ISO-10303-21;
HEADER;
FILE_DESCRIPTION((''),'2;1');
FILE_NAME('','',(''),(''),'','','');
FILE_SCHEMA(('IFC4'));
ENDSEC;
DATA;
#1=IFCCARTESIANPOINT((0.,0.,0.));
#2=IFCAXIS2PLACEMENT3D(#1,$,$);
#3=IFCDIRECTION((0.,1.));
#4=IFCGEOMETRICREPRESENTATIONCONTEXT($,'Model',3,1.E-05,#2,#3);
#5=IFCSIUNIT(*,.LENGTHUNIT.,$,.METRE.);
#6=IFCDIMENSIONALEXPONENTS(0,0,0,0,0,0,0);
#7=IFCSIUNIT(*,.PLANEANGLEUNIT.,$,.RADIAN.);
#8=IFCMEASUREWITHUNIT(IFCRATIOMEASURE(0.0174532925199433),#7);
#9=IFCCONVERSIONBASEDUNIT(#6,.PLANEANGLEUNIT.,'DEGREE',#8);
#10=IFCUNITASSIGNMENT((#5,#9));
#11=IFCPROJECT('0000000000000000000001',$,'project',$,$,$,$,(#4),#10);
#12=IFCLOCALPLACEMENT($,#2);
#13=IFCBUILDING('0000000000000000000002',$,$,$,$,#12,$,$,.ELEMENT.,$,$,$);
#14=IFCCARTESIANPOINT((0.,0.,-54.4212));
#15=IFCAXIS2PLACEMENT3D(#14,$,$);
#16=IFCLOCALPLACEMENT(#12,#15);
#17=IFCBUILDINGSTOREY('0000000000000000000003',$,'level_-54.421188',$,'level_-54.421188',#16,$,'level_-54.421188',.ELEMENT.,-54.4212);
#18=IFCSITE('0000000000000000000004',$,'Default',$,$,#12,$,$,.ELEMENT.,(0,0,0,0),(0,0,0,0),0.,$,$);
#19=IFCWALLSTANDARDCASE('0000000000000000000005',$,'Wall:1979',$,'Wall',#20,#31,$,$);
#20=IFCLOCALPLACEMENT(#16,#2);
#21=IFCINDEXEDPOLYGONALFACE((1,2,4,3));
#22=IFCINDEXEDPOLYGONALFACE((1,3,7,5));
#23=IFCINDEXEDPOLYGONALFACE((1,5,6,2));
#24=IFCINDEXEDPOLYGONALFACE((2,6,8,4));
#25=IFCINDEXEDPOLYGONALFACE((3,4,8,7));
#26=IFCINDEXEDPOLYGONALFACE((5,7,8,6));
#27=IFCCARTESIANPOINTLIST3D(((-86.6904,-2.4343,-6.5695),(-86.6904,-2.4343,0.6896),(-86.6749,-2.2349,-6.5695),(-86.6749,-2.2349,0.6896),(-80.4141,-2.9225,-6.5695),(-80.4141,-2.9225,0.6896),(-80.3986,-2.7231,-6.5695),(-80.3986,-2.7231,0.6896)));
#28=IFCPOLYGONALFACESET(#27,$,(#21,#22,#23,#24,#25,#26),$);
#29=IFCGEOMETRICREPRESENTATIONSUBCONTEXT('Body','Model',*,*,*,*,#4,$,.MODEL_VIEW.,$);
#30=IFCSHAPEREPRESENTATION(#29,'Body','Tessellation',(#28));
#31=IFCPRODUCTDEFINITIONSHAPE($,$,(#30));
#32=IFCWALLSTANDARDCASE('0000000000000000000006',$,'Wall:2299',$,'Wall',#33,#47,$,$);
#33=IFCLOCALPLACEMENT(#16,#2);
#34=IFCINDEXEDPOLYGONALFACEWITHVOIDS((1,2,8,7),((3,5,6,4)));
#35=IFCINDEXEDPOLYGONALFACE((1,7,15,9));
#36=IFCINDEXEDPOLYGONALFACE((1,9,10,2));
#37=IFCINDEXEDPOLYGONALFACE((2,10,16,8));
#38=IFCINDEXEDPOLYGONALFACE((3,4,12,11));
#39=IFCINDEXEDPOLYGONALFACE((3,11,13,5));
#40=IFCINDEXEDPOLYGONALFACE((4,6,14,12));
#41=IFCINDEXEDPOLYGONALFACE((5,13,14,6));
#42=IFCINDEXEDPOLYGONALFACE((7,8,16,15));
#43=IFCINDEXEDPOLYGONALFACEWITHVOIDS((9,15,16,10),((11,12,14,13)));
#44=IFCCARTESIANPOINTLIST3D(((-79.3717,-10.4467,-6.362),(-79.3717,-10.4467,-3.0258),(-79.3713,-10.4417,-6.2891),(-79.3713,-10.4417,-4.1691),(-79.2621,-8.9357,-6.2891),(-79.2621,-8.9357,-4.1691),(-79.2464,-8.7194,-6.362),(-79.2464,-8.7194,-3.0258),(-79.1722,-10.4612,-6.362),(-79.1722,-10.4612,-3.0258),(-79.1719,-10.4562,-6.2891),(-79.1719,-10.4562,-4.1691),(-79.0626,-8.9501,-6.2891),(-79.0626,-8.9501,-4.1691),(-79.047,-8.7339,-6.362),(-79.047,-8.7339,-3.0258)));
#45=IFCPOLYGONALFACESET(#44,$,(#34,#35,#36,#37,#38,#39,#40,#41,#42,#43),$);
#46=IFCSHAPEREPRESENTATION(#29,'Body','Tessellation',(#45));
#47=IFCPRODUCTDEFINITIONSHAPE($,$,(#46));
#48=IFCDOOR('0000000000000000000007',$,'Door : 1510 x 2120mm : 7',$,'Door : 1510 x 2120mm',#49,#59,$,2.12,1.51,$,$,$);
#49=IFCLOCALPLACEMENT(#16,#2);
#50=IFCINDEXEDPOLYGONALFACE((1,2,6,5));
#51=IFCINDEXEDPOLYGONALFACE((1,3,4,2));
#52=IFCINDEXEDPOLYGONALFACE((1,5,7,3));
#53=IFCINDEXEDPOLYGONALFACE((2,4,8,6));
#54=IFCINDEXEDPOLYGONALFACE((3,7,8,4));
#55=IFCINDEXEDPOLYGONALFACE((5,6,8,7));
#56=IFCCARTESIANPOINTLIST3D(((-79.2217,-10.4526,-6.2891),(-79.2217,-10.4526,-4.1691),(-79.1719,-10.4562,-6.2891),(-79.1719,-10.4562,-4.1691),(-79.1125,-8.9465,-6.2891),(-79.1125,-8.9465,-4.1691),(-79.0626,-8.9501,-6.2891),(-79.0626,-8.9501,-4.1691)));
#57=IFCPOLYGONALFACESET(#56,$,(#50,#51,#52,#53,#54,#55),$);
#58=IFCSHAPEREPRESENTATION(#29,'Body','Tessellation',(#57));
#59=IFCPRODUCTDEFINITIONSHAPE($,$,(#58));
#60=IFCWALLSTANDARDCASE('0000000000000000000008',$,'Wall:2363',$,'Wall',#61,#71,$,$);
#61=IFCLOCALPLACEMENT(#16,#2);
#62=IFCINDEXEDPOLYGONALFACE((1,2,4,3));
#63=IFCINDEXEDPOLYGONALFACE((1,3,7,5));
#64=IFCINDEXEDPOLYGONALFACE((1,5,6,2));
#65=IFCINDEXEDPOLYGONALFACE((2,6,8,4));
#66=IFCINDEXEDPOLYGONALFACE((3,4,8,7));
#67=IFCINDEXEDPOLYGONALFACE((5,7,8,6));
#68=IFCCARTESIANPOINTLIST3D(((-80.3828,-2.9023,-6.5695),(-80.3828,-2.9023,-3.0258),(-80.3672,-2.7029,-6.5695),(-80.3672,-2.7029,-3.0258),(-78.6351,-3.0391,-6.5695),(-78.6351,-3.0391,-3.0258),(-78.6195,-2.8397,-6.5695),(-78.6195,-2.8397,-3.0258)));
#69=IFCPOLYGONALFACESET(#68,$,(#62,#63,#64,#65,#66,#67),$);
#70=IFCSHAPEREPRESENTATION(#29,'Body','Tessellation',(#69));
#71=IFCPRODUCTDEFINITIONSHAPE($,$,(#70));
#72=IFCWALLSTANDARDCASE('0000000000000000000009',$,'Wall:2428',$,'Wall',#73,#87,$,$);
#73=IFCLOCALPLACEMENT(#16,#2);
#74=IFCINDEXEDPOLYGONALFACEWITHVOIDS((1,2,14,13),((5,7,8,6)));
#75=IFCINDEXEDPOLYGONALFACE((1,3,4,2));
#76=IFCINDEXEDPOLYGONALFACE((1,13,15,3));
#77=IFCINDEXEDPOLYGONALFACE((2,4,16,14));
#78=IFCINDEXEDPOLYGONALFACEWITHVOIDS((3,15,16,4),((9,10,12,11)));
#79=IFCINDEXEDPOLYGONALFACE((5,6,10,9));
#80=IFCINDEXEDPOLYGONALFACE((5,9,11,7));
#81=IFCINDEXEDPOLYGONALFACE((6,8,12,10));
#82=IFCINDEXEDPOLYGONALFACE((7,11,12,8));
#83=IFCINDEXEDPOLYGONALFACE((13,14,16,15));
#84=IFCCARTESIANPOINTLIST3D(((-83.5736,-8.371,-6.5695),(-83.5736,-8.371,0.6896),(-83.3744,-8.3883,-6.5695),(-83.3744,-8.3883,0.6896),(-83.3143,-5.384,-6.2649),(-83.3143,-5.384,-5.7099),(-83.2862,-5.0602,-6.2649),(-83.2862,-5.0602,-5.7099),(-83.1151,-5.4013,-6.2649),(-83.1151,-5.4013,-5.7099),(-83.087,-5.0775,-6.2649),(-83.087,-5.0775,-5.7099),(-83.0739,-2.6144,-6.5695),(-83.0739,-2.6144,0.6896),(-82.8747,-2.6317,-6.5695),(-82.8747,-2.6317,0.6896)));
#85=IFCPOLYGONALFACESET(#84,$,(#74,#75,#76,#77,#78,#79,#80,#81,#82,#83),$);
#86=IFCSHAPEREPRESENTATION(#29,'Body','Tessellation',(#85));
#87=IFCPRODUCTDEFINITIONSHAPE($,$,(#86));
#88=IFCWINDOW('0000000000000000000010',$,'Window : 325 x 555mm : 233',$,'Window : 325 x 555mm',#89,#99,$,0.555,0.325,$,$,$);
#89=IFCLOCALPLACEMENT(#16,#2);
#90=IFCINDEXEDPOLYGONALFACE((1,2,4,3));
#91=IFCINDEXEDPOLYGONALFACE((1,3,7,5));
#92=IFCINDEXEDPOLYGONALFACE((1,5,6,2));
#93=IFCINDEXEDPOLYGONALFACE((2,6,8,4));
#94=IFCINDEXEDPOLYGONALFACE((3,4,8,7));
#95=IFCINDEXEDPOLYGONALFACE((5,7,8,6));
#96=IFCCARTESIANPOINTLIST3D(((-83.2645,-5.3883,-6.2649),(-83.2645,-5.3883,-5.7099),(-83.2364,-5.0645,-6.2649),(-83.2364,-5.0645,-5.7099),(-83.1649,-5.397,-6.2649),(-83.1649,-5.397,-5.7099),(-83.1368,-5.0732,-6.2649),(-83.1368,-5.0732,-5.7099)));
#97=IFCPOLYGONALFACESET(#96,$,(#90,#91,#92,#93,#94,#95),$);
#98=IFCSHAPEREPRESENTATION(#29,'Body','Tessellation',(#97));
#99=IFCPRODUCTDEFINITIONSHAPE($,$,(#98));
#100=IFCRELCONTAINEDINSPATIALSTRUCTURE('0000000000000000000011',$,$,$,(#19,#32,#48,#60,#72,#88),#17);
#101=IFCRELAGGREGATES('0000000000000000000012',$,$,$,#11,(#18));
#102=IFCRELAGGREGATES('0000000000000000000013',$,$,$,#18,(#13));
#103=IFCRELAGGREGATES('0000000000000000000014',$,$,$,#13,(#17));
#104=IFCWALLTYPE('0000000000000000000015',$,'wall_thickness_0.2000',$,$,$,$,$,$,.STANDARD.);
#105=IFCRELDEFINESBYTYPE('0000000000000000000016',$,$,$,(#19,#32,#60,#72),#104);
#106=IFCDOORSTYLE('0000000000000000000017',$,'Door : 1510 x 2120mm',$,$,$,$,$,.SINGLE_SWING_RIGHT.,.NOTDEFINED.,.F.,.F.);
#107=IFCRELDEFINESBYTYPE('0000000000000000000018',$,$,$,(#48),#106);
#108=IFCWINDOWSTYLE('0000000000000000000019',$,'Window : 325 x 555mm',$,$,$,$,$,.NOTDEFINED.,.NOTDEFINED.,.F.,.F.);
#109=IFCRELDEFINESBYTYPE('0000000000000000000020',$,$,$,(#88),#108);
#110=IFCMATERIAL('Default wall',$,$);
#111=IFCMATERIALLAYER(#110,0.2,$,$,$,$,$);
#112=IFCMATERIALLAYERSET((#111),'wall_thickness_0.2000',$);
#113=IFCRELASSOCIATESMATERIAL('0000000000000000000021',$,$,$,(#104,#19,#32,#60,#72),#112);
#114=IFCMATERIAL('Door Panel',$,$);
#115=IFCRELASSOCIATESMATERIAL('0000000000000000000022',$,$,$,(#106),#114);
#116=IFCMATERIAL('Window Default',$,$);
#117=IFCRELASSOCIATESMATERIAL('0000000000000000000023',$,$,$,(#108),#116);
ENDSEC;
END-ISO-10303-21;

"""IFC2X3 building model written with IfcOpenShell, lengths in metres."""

from ifc_helpers import new_model, entity, si_unit, converted_unit, direction, frame, frame_2d, origin, origin_2d_with_axis, place, context, subcontext, project, spatial, polyline, rectangle, outline, extrude, source, transform, mapped, material, layer, layer_set, layer_usage, type_object, type_shapes, element, fill, save


model = new_model("IFC2X3")

# Units and contexts
model_context = context("Model", 3, precision=1e-05, world=origin(), true_north=direction((0.0, 1.0)))
body_context = subcontext(model_context, "Body", "Model", "MODEL_VIEW")
ifc_project = project(units=[si_unit("LENGTHUNIT", "METRE"), converted_unit("PLANEANGLEUNIT", "DEGREE", entity("IfcRatioMeasure", 0.0174532925199433), si_unit("PLANEANGLEUNIT", "RADIAN"), dimensions=[0, 0, 0, 0, 0, 0, 0])], contexts=[model_context])

# Site, building, storey
placement_1 = place(None, origin())
site = spatial("IfcSite", under=ifc_project, at=placement_1, Name="Default", CompositionType="ELEMENT", RefLatitude=(0, 0, 0, 0), RefLongitude=(0, 0, 0, 0), RefElevation=0.0)
building = spatial("IfcBuilding", under=site, at=placement_1, CompositionType="ELEMENT")
storey_placement = place(placement_1, frame((0.0, 0.0, -54.4212)))
storey = spatial("IfcBuildingStorey", under=building, at=storey_placement, Name="level_-54.421188", ObjectType="level_-54.421188", LongName="level_-54.421188", CompositionType="ELEMENT", Elevation=-54.4212)

# Shared definitions
ifc_material_1 = material(Name="Default wall")
ifc_layer = layer(ifc_material_1, 0.2)
ifc_layer_set = layer_set([ifc_layer], Name="wall_thickness_0.2000")
ifc_layer_usage = layer_usage(ifc_layer_set, "AXIS2", "POSITIVE", -0.1)
wall_type = type_object("IfcWallType", Name="wall_thickness_0.2000", PredefinedType="STANDARD", material=ifc_layer_set)

# Shared definitions
ifc_material_2 = material(Name="Window Default")

# Shared definitions
ifc_material_3 = material(Name="Door Panel")

# Wall
placement_2 = place(placement_1, frame((0.0, 0.0, -60.9907)))
wall_1_placement = place(placement_2, frame((-80.4063, -2.8228, 0.0), z_axis=(0.0, 0.0, 1.0), x_axis=(-0.996989, 0.07754, 0.0)))
element("IfcWallStandardCase", 1, at=wall_1_placement, inside=storey, type_object=wall_type, material=ifc_layer_usage, Name="Wall:1979", ObjectType="Wall", context=body_context, shape_type="SweptSolid", body=[
    extrude(outline(polyline([(6.2953, -0.1), (6.2953, 0.1), (0.0, 0.1), (0.0, -0.1), (6.2953, -0.1)])), origin(), (0.0, 0.0, 1.0), 7.259),
])

# Wall, opening, door
placement_3 = place(placement_1, frame((0.0, 0.0, -60.7832)))
wall_2_placement = place(placement_3, frame((-79.1467, -8.7266, 0.0), z_axis=(0.0, 0.0, 1.0), x_axis=(-0.072341, -0.99738, 0.0)))
wall_2 = element("IfcWallStandardCase", 2, at=wall_2_placement, inside=storey, type_object=wall_type, material=ifc_layer_usage, Name="Wall:2299", ObjectType="Wall", context=body_context, shape_type="SweptSolid", body=[
    extrude(outline(polyline([(1.7318, -0.1), (1.7318, 0.1), (0.0, 0.1), (0.0, -0.1), (1.7318, -0.1)])), origin(), (0.0, 0.0, 1.0), 3.3362),
])
opening_1_placement = place(wall_2_placement, frame((0.2168, -0.1, 0.0729)))
opening_1 = element("IfcOpeningElement", 3, at=opening_1_placement, cuts=wall_2, ObjectType="Opening", context=body_context, shape_type="SweptSolid", body=[
    extrude(rectangle(XDim=1.51, YDim=2.12, at=frame_2d((1.06, 0.755), x_axis=(0.0, 1.0))), frame((0.0, 0.0, 0.0), z_axis=(0.0, 1.0, 0.0), x_axis=(0.0, 0.0, 1.0)), (0.0, 0.0, 1.0), 0.2),
])
door_style_1 = type_object("IfcDoorStyle", Name="Door : 1510 x 2120mm", ConstructionType="NOTDEFINED", OperationType="SINGLE_SWING_RIGHT", ParameterTakesPrecedence=False, Sizeable=False, material=ifc_material_3)
shared_shape_1 = source(origin(), body_context, "Body", "SweptSolid", [
    extrude(rectangle(XDim=0.05, YDim=1.51, at=origin_2d_with_axis()), frame((0.755, 0.175, 0.0), z_axis=(0.0, 0.0, 1.0), x_axis=(0.0, 1.0, 0.0)), (0.0, 0.0, 1.0), 2.12),
])
type_shapes(door_style_1, [shared_shape_1])
door_1_placement = place(opening_1_placement, origin())
door_1 = element("IfcDoor", 4, at=door_1_placement, inside=storey, type_object=door_style_1, Name="Door : 1510 x 2120mm : 7", ObjectType="Door : 1510 x 2120mm", OverallHeight=2.12, OverallWidth=1.51, context=body_context, shape_type="MappedRepresentation", body=[
    mapped(shared_shape_1, transform((0.0, 0.0, 0.0), scale=1.0)),
])
fill(opening_1, door_1)

# Wall
placement_4 = place(placement_1, frame((0.0, 0.0, -60.9907)))
wall_3_placement = place(placement_4, frame((-80.375, -2.8026, 0.0), z_axis=(0.0, 0.0, 1.0), x_axis=(0.996952, -0.078016, 0.0)))
element("IfcWallStandardCase", 5, at=wall_3_placement, inside=storey, type_object=wall_type, material=ifc_layer_usage, Name="Wall:2363", ObjectType="Wall", context=body_context, shape_type="SweptSolid", body=[
    extrude(outline(polyline([(1.753, -0.1), (1.753, 0.1), (0.0, 0.1), (0.0, -0.1), (1.753, -0.1)])), origin(), (0.0, 0.0, 1.0), 3.5437),
])

# Wall, opening, window
placement_5 = place(placement_1, frame((0.0, 0.0, -60.9907)))
wall_4_placement = place(placement_5, frame((-82.9743, -2.6231, 0.0), z_axis=(0.0, 0.0, 1.0), x_axis=(-0.086479, -0.996254, 0.0)))
wall_4 = element("IfcWallStandardCase", 6, at=wall_4_placement, inside=storey, type_object=wall_type, material=ifc_layer_usage, Name="Wall:2428", ObjectType="Wall", context=body_context, shape_type="SweptSolid", body=[
    extrude(outline(polyline([(5.7782, -0.1), (5.7782, 0.1), (0.0, 0.1), (0.0, -0.1), (5.7782, -0.1)])), origin(), (0.0, 0.0, 1.0), 7.259),
])
opening_2_placement = place(wall_4_placement, frame((2.455, -0.1, 0.3046)))
opening_2 = element("IfcOpeningElement", 7, at=opening_2_placement, cuts=wall_4, ObjectType="Opening", context=body_context, shape_type="SweptSolid", body=[
    extrude(rectangle(XDim=0.325, YDim=0.555, at=frame_2d((0.2775, 0.1625), x_axis=(0.0, 1.0))), frame((0.0, 0.0, 0.0), z_axis=(0.0, 1.0, 0.0), x_axis=(0.0, 0.0, 1.0)), (0.0, 0.0, 1.0), 0.2),
])
window_style_1 = type_object("IfcWindowStyle", Name="Window : 325 x 555mm", ConstructionType="NOTDEFINED", OperationType="NOTDEFINED", ParameterTakesPrecedence=False, Sizeable=False, material=ifc_material_2)
shared_shape_2 = source(origin(), body_context, "Body", "SweptSolid", [
    extrude(rectangle(XDim=0.1, YDim=0.325, at=origin_2d_with_axis()), frame((0.1625, 0.1, 0.0), z_axis=(0.0, 0.0, 1.0), x_axis=(0.0, 1.0, 0.0)), (0.0, 0.0, 1.0), 0.555),
])
type_shapes(window_style_1, [shared_shape_2])
window_1_placement = place(opening_2_placement, origin())
window_1 = element("IfcWindow", 8, at=window_1_placement, inside=storey, type_object=window_style_1, Name="Window : 325 x 555mm : 233", ObjectType="Window : 325 x 555mm", OverallHeight=0.555, OverallWidth=0.325, context=body_context, shape_type="MappedRepresentation", body=[
    mapped(shared_shape_2, transform((0.0, 0.0, 0.0), scale=1.0)),
])
fill(opening_2, window_1)

save(model, "model.ifc")
